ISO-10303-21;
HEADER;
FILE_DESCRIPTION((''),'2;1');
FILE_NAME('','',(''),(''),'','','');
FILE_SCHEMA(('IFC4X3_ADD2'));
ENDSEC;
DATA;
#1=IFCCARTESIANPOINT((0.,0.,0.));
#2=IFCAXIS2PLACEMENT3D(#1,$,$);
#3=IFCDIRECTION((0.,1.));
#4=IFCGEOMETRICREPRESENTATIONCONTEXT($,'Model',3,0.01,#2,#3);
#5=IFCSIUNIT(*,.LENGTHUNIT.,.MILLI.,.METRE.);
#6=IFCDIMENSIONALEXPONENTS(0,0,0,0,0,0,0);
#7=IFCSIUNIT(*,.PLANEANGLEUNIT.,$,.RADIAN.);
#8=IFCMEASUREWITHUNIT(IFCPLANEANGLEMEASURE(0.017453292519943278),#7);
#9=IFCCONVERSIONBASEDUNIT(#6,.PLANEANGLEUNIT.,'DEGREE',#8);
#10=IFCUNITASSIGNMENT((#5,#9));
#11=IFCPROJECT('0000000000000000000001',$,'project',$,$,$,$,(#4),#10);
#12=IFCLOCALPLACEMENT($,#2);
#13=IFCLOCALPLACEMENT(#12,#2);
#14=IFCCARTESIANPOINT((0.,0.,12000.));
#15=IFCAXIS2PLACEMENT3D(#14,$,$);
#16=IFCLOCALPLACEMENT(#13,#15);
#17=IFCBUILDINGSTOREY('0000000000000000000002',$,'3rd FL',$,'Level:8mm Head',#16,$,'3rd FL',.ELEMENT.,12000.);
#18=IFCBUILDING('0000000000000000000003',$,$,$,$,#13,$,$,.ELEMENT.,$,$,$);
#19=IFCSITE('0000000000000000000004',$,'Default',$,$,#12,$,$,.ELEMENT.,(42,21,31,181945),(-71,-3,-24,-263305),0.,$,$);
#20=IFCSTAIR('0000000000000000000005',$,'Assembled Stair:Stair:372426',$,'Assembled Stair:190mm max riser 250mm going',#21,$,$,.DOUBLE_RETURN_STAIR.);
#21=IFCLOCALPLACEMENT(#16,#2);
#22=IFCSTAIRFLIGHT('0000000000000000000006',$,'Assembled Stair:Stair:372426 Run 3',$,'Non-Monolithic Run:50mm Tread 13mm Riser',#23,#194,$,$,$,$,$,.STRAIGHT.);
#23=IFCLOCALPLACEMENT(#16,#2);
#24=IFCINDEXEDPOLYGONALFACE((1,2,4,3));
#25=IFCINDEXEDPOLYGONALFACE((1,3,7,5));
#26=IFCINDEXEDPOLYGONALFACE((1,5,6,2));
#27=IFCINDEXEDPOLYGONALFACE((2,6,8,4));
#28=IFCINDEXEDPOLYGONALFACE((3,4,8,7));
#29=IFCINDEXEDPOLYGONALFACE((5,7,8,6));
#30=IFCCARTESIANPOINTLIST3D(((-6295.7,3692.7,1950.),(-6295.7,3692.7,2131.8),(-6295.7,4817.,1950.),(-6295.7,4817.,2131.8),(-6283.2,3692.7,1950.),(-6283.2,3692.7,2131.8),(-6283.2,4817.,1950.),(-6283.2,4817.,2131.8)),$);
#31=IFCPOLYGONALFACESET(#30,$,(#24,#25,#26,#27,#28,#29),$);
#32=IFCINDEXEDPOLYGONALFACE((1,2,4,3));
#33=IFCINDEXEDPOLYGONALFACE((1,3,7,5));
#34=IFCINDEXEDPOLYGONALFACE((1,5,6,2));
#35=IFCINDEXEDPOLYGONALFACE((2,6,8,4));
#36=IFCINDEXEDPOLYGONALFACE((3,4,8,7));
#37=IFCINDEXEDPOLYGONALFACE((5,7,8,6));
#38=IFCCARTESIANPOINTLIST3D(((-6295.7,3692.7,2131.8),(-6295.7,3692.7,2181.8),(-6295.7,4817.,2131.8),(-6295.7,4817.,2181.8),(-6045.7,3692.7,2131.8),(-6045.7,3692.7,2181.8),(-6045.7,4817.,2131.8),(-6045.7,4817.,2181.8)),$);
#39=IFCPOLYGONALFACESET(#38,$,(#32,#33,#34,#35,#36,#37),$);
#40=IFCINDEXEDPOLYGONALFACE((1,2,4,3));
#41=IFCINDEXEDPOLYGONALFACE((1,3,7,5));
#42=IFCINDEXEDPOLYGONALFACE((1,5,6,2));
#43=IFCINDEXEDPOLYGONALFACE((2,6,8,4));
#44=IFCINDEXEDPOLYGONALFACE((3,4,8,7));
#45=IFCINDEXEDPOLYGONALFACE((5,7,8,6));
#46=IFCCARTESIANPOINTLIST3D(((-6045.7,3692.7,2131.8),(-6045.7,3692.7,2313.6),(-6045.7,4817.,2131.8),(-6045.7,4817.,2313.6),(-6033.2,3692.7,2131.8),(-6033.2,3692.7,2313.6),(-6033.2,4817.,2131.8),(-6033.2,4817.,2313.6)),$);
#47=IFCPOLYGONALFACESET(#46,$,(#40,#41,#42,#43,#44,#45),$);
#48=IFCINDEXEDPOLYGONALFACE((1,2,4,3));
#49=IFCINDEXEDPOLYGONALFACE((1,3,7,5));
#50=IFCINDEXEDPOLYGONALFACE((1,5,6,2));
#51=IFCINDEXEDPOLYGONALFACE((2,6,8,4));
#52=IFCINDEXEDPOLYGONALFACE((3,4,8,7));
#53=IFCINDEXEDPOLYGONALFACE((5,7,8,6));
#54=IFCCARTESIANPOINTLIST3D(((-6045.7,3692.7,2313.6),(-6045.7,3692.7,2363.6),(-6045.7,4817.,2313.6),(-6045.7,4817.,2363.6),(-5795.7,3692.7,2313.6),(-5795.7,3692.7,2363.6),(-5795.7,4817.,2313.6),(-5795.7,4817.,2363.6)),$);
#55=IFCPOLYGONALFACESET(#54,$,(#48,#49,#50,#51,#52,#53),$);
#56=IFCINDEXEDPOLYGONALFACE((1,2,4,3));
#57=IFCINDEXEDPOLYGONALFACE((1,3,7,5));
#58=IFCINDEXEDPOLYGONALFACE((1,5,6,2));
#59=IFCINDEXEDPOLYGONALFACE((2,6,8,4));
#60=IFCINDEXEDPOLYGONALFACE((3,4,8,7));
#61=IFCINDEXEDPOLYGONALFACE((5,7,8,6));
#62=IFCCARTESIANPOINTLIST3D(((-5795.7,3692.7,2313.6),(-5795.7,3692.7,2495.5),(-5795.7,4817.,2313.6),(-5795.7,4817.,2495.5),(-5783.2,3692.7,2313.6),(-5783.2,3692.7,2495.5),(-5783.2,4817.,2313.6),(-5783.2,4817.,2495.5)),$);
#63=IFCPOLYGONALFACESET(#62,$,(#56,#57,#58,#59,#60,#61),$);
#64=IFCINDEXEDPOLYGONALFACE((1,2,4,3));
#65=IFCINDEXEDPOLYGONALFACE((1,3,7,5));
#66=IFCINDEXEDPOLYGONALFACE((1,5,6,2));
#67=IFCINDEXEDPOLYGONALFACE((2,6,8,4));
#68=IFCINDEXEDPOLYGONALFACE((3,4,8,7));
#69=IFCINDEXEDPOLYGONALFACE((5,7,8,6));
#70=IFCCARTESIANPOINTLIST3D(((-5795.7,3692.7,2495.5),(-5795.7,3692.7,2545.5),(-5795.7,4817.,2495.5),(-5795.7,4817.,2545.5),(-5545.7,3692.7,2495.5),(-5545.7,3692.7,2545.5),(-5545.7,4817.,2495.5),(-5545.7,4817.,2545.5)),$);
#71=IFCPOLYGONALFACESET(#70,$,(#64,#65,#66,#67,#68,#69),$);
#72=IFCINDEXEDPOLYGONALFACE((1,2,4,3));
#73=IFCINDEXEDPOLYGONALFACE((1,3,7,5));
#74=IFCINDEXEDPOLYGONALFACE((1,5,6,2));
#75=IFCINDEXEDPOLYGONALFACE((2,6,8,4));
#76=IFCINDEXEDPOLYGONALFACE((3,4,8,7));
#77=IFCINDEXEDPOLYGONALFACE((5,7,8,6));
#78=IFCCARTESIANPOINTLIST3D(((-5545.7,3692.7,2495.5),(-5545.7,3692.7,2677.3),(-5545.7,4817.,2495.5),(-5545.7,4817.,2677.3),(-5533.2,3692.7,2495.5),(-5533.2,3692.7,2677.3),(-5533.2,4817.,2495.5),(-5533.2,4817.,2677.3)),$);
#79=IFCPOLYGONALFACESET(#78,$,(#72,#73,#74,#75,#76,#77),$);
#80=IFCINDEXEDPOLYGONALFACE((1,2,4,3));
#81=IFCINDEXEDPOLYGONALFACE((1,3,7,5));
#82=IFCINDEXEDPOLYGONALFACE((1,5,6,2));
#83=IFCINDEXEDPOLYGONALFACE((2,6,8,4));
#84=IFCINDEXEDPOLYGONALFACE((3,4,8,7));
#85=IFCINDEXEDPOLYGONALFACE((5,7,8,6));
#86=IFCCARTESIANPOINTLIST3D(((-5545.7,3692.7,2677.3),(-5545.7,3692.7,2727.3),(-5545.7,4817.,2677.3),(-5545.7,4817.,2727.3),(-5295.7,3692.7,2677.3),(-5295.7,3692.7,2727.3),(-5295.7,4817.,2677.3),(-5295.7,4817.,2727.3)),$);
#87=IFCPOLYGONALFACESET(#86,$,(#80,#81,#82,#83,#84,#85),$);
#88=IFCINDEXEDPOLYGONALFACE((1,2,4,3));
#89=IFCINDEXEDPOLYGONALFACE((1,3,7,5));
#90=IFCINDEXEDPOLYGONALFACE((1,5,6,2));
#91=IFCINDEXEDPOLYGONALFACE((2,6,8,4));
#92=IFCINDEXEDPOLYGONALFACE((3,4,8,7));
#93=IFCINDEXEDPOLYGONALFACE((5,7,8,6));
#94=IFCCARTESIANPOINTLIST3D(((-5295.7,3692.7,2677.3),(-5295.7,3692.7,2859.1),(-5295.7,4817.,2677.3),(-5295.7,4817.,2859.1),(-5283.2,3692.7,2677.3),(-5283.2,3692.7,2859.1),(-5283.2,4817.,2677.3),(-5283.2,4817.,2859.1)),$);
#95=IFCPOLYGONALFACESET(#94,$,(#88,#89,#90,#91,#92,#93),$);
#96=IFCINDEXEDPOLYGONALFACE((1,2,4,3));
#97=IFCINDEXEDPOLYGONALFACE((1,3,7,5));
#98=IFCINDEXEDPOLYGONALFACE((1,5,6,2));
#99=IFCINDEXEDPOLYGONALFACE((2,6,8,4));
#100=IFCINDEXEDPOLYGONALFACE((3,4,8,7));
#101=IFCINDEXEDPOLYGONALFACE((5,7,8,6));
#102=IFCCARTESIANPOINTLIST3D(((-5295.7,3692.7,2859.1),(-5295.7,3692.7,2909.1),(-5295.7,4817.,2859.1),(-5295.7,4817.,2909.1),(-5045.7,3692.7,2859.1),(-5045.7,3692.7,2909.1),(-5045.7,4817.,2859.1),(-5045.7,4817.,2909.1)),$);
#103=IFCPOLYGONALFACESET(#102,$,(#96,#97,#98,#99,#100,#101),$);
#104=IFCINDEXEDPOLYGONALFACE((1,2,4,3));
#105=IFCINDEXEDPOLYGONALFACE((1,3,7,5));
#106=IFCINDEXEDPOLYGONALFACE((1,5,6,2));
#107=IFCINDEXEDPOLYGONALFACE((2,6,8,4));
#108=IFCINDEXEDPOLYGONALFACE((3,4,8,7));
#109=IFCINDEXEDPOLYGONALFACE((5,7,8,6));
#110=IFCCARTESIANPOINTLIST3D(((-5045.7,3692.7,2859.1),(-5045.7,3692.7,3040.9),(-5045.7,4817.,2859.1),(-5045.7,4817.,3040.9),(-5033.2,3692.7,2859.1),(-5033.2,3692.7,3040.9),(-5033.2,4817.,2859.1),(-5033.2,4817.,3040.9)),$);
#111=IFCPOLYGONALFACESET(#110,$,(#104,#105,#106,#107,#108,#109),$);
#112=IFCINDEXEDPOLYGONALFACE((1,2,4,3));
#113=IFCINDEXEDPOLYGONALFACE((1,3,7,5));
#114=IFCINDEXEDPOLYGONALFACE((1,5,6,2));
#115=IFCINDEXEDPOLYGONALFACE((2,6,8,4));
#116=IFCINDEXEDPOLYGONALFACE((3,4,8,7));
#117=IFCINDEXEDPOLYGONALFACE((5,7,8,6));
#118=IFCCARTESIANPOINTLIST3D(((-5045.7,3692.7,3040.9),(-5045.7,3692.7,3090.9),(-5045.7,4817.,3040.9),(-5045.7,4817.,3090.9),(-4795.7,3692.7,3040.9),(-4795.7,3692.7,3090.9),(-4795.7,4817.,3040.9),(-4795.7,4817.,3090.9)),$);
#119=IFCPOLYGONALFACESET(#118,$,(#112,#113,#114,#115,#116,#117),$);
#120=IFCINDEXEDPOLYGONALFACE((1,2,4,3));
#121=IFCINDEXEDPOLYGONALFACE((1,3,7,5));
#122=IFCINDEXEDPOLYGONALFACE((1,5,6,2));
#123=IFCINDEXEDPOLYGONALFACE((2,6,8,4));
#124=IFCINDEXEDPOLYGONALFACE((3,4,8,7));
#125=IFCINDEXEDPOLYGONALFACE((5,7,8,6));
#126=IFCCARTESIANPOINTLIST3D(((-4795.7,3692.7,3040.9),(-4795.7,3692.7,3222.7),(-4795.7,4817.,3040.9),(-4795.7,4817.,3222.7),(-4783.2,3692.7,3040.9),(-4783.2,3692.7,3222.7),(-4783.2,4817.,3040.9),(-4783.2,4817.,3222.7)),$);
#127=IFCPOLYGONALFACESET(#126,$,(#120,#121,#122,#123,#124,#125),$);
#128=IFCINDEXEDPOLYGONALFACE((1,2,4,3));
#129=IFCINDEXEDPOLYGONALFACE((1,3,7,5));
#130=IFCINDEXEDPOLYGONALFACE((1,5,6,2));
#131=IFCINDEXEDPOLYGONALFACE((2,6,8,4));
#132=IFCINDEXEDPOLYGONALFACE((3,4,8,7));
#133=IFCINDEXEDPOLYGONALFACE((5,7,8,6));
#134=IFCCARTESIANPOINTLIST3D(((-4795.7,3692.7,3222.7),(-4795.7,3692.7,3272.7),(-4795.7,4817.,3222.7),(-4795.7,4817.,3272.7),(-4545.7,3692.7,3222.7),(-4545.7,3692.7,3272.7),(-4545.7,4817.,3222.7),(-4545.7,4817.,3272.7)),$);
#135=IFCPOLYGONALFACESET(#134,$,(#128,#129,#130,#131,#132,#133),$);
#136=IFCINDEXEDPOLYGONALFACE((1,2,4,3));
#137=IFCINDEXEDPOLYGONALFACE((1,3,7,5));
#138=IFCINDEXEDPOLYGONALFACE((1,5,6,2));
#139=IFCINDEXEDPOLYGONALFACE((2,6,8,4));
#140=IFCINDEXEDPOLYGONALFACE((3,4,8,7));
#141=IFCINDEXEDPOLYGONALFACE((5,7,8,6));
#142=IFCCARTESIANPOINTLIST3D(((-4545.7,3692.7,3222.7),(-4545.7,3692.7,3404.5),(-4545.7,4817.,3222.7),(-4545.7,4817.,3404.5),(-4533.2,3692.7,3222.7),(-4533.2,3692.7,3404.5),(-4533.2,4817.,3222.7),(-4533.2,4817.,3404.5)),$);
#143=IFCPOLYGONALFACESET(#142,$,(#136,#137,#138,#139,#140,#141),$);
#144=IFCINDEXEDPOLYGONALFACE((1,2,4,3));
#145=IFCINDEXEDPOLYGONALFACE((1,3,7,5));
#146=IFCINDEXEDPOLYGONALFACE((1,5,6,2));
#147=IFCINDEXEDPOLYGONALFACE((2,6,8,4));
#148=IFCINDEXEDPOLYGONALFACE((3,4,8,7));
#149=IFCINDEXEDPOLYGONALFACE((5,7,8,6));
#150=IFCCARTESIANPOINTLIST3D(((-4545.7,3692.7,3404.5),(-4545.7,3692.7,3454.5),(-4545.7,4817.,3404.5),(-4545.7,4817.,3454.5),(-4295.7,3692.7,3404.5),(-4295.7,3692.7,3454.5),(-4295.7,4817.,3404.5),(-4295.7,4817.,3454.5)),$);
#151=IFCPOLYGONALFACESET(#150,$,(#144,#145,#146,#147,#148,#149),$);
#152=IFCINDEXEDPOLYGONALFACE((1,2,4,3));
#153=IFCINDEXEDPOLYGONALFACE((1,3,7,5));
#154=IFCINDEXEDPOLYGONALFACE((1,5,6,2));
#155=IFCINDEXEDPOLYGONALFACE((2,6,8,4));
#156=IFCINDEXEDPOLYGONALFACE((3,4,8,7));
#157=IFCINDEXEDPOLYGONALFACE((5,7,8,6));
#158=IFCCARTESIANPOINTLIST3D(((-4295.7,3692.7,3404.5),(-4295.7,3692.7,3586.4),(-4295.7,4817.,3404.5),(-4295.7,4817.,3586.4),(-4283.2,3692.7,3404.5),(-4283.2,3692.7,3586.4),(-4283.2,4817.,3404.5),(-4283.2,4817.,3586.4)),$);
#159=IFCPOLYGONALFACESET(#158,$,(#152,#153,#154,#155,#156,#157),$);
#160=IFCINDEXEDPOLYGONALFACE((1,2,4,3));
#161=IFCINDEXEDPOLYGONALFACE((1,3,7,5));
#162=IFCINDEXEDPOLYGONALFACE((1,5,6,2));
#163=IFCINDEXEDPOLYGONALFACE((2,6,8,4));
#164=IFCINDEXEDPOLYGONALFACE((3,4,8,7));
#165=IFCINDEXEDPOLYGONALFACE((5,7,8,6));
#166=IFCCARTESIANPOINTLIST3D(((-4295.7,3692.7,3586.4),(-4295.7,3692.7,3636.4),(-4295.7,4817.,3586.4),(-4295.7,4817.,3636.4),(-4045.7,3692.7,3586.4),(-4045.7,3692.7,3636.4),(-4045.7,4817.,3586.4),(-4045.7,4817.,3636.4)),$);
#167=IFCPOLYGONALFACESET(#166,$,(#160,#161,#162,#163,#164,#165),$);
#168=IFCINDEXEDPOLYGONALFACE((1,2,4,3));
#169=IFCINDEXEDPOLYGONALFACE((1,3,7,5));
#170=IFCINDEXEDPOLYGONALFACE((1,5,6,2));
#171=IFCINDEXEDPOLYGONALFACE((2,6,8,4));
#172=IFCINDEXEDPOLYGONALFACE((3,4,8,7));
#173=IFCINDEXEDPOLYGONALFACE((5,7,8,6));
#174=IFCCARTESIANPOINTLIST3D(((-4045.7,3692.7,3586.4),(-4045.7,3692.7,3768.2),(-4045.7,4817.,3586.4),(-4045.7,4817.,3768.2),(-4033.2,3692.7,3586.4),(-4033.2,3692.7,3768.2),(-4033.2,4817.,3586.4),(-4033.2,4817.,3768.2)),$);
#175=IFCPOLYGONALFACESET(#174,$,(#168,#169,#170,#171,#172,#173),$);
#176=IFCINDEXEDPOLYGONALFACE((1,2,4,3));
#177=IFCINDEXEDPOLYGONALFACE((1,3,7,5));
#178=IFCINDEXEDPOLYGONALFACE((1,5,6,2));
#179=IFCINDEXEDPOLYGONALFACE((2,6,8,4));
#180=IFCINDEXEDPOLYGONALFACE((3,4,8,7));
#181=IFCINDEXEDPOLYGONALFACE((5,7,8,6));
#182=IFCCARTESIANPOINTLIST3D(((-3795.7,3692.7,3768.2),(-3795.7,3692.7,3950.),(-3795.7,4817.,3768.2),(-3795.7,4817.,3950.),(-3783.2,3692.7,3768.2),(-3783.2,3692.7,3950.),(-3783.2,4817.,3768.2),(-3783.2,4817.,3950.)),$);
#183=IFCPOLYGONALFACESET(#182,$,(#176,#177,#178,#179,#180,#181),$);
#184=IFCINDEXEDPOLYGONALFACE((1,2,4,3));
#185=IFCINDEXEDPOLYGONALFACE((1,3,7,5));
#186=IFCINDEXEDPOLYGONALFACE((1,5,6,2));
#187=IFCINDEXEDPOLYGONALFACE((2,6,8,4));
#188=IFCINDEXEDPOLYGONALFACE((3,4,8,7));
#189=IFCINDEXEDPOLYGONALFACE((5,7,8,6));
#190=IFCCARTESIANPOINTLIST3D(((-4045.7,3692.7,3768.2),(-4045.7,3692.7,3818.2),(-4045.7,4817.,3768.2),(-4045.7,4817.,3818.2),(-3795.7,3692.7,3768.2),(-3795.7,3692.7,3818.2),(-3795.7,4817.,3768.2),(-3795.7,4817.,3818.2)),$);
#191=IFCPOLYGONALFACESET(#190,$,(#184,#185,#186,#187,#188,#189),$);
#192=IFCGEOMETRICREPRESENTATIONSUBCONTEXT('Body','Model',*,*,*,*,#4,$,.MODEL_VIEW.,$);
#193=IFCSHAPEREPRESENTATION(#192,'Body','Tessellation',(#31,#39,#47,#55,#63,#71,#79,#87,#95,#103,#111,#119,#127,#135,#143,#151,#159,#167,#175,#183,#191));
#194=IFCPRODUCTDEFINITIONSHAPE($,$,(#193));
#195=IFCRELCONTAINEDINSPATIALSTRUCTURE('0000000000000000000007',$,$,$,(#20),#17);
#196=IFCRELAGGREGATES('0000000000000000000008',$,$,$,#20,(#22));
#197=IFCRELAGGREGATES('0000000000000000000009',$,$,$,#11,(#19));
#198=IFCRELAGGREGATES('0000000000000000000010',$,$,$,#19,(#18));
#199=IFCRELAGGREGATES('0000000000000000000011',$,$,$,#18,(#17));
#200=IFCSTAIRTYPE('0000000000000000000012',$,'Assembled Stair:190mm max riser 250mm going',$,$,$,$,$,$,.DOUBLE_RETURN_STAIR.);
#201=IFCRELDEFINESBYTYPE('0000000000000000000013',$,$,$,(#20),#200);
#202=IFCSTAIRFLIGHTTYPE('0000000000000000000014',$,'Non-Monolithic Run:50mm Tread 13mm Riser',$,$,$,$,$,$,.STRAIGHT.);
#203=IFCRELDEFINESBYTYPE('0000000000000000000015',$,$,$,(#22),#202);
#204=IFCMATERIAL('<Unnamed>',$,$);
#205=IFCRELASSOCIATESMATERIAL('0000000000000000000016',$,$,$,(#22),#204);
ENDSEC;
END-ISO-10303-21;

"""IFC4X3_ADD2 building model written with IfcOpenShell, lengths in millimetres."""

from ifc_helpers import new_model, entity, si_unit, converted_unit, direction, frame, frame_2d, origin, origin_2d_with_axis, place, context, subcontext, project, spatial, rectangle, extrude, material, type_object, element, aggregate, save


model = new_model("IFC4X3_ADD2")

# Units and contexts
model_context = context("Model", 3, precision=0.01, world=origin(), true_north=direction((0.0, 1.0)))
body_context = subcontext(model_context, "Body", "Model", "MODEL_VIEW")
ifc_project = project(units=[si_unit("LENGTHUNIT", "METRE", prefix="MILLI"), converted_unit("PLANEANGLEUNIT", "DEGREE", entity("IfcPlaneAngleMeasure", 0.017453292519943278), si_unit("PLANEANGLEUNIT", "RADIAN"), dimensions=[0, 0, 0, 0, 0, 0, 0])], contexts=[model_context])

# Site, building, storey
site_placement = place(None, origin())
site = spatial("IfcSite", under=ifc_project, at=site_placement, Name="Default", CompositionType="ELEMENT", RefLatitude=(42, 21, 31, 181945), RefLongitude=(-71, -3, -24, -263305), RefElevation=0.0)
building_placement = place(site_placement, origin())
building = spatial("IfcBuilding", under=site, at=building_placement, CompositionType="ELEMENT")
storey_placement = place(building_placement, frame((0.0, 0.0, 12000.0)))
storey = spatial("IfcBuildingStorey", under=building, at=storey_placement, Name="3rd FL", ObjectType="Level:8mm Head", LongName="3rd FL", CompositionType="ELEMENT", Elevation=12000.0)

# Stair
stair_type = type_object("IfcStairType", Name="Assembled Stair:190mm max riser 250mm going", PredefinedType="DOUBLE_RETURN_STAIR")
stair_placement = place(storey_placement, origin())
stair = element("IfcStair", 1, at=stair_placement, inside=storey, type_object=stair_type, Name="Assembled Stair:Stair:372426", ObjectType="Assembled Stair:190mm max riser 250mm going", PredefinedType="DOUBLE_RETURN_STAIR")
ifc_material_1 = material(Name="<Unnamed>")

# Stair flight
stair_flight_type = type_object("IfcStairFlightType", Name="Non-Monolithic Run:50mm Tread 13mm Riser", PredefinedType="STRAIGHT")
stair_flight_1_placement = place(stair_placement, frame((-6295.7, 3692.7, 0.0)))
stair_flight_1 = element("IfcStairFlight", 2, at=stair_flight_1_placement, type_object=stair_flight_type, material=ifc_material_1, Name="Assembled Stair:Stair:372426 Run 3", ObjectType="Non-Monolithic Run:50mm Tread 13mm Riser", PredefinedType="STRAIGHT", context=body_context, shape_type="SweptSolid", body=[
    extrude(rectangle(XDim=1124.3, YDim=12.5, at=frame_2d((0.0, 0.0), x_axis=(1.0, 0.0))), frame((6.3, 562.2, 1950.0), z_axis=(0.0, 0.0, 1.0), x_axis=(0.0, 1.0, 0.0)), (0.0, 0.0, 1.0), 181.8),
    extrude(rectangle(XDim=250.0, YDim=1124.3, at=frame_2d((0.0, 0.0), x_axis=(1.0, 0.0))), frame((125.0, 562.2, 2131.8), z_axis=(0.0, 0.0, 1.0), x_axis=(-1.0, 0.0, 0.0)), (0.0, 0.0, 1.0), 50.0),
    extrude(rectangle(XDim=1124.3, YDim=12.5, at=frame_2d((0.0, 0.0), x_axis=(1.0, 0.0))), frame((256.3, 562.2, 2131.8), z_axis=(0.0, 0.0, 1.0), x_axis=(0.0, 1.0, 0.0)), (0.0, 0.0, 1.0), 181.8),
    extrude(rectangle(XDim=250.0, YDim=1124.3, at=frame_2d((0.0, 0.0), x_axis=(1.0, 0.0))), frame((375.0, 562.2, 2313.6), z_axis=(0.0, 0.0, 1.0), x_axis=(-1.0, 0.0, 0.0)), (0.0, 0.0, 1.0), 50.0),
    extrude(rectangle(XDim=1124.3, YDim=12.5, at=frame_2d((0.0, 0.0), x_axis=(1.0, 0.0))), frame((506.3, 562.2, 2313.6), z_axis=(0.0, 0.0, 1.0), x_axis=(0.0, 1.0, 0.0)), (0.0, 0.0, 1.0), 181.8),
    extrude(rectangle(XDim=250.0, YDim=1124.3, at=frame_2d((0.0, 0.0), x_axis=(1.0, 0.0))), frame((625.0, 562.2, 2495.5), z_axis=(0.0, 0.0, 1.0), x_axis=(-1.0, 0.0, 0.0)), (0.0, 0.0, 1.0), 50.0),
    extrude(rectangle(XDim=1124.3, YDim=12.5, at=frame_2d((0.0, 0.0), x_axis=(1.0, 0.0))), frame((756.3, 562.2, 2495.5), z_axis=(0.0, 0.0, 1.0), x_axis=(0.0, 1.0, 0.0)), (0.0, 0.0, 1.0), 181.8),
    extrude(rectangle(XDim=250.0, YDim=1124.3, at=frame_2d((0.0, 0.0), x_axis=(1.0, 0.0))), frame((875.0, 562.2, 2677.3), z_axis=(0.0, 0.0, 1.0), x_axis=(-1.0, 0.0, 0.0)), (0.0, 0.0, 1.0), 50.0),
    extrude(rectangle(XDim=1124.3, YDim=12.5, at=frame_2d((0.0, 0.0), x_axis=(1.0, 0.0))), frame((1006.3, 562.2, 2677.3), z_axis=(0.0, 0.0, 1.0), x_axis=(0.0, 1.0, 0.0)), (0.0, 0.0, 1.0), 181.8),
    extrude(rectangle(XDim=250.0, YDim=1124.3, at=frame_2d((0.0, 0.0), x_axis=(1.0, 0.0))), frame((1125.0, 562.2, 2859.1), z_axis=(0.0, 0.0, 1.0), x_axis=(-1.0, 0.0, 0.0)), (0.0, 0.0, 1.0), 50.0),
    extrude(rectangle(XDim=1124.3, YDim=12.5, at=frame_2d((0.0, 0.0), x_axis=(1.0, 0.0))), frame((1256.3, 562.2, 2859.1), z_axis=(0.0, 0.0, 1.0), x_axis=(0.0, 1.0, 0.0)), (0.0, 0.0, 1.0), 181.8),
    extrude(rectangle(XDim=250.0, YDim=1124.3, at=frame_2d((0.0, 0.0), x_axis=(1.0, 0.0))), frame((1375.0, 562.2, 3040.9), z_axis=(0.0, 0.0, 1.0), x_axis=(-1.0, 0.0, 0.0)), (0.0, 0.0, 1.0), 50.0),
    extrude(rectangle(XDim=1124.3, YDim=12.5, at=frame_2d((0.0, 0.0), x_axis=(1.0, 0.0))), frame((1506.3, 562.2, 3040.9), z_axis=(0.0, 0.0, 1.0), x_axis=(0.0, 1.0, 0.0)), (0.0, 0.0, 1.0), 181.8),
    extrude(rectangle(XDim=250.0, YDim=1124.3, at=frame_2d((0.0, 0.0), x_axis=(1.0, 0.0))), frame((1625.0, 562.2, 3222.7), z_axis=(0.0, 0.0, 1.0), x_axis=(-1.0, 0.0, 0.0)), (0.0, 0.0, 1.0), 50.0),
    extrude(rectangle(XDim=1124.3, YDim=12.5, at=frame_2d((0.0, 0.0), x_axis=(1.0, 0.0))), frame((1756.3, 562.2, 3222.7), z_axis=(0.0, 0.0, 1.0), x_axis=(0.0, 1.0, 0.0)), (0.0, 0.0, 1.0), 181.8),
    extrude(rectangle(XDim=250.0, YDim=1124.3, at=frame_2d((0.0, 0.0), x_axis=(1.0, 0.0))), frame((1875.0, 562.2, 3404.5), z_axis=(0.0, 0.0, 1.0), x_axis=(-1.0, 0.0, 0.0)), (0.0, 0.0, 1.0), 50.0),
    extrude(rectangle(XDim=1124.3, YDim=12.5, at=origin_2d_with_axis()), frame((2006.3, 562.2, 3404.5), z_axis=(0.0, 0.0, 1.0), x_axis=(0.0, 1.0, 0.0)), (0.0, 0.0, 1.0), 181.8),
    extrude(rectangle(XDim=250.0, YDim=1124.3, at=frame_2d((0.0, 0.0), x_axis=(1.0, 0.0))), frame((2125.0, 562.2, 3586.4), z_axis=(0.0, 0.0, 1.0), x_axis=(-1.0, 0.0, 0.0)), (0.0, 0.0, 1.0), 50.0),
    extrude(rectangle(XDim=1124.3, YDim=12.5, at=frame_2d((0.0, 0.0), x_axis=(1.0, 0.0))), frame((2256.3, 562.2, 3586.4), z_axis=(0.0, 0.0, 1.0), x_axis=(0.0, 1.0, 0.0)), (0.0, 0.0, 1.0), 181.8),
    extrude(rectangle(XDim=1124.3, YDim=12.5, at=origin_2d_with_axis()), frame((2506.3, 562.2, 3768.2), z_axis=(0.0, 0.0, 1.0), x_axis=(0.0, 1.0, 0.0)), (0.0, 0.0, 1.0), 181.8),
    extrude(rectangle(XDim=250.0, YDim=1124.3, at=frame_2d((0.0, 0.0), x_axis=(1.0, 0.0))), frame((2375.0, 562.2, 3768.2), z_axis=(0.0, 0.0, 1.0), x_axis=(-1.0, 0.0, 0.0)), (0.0, 0.0, 1.0), 50.0),
])
aggregate(stair, [stair_flight_1])

save(model, "model.ifc")
